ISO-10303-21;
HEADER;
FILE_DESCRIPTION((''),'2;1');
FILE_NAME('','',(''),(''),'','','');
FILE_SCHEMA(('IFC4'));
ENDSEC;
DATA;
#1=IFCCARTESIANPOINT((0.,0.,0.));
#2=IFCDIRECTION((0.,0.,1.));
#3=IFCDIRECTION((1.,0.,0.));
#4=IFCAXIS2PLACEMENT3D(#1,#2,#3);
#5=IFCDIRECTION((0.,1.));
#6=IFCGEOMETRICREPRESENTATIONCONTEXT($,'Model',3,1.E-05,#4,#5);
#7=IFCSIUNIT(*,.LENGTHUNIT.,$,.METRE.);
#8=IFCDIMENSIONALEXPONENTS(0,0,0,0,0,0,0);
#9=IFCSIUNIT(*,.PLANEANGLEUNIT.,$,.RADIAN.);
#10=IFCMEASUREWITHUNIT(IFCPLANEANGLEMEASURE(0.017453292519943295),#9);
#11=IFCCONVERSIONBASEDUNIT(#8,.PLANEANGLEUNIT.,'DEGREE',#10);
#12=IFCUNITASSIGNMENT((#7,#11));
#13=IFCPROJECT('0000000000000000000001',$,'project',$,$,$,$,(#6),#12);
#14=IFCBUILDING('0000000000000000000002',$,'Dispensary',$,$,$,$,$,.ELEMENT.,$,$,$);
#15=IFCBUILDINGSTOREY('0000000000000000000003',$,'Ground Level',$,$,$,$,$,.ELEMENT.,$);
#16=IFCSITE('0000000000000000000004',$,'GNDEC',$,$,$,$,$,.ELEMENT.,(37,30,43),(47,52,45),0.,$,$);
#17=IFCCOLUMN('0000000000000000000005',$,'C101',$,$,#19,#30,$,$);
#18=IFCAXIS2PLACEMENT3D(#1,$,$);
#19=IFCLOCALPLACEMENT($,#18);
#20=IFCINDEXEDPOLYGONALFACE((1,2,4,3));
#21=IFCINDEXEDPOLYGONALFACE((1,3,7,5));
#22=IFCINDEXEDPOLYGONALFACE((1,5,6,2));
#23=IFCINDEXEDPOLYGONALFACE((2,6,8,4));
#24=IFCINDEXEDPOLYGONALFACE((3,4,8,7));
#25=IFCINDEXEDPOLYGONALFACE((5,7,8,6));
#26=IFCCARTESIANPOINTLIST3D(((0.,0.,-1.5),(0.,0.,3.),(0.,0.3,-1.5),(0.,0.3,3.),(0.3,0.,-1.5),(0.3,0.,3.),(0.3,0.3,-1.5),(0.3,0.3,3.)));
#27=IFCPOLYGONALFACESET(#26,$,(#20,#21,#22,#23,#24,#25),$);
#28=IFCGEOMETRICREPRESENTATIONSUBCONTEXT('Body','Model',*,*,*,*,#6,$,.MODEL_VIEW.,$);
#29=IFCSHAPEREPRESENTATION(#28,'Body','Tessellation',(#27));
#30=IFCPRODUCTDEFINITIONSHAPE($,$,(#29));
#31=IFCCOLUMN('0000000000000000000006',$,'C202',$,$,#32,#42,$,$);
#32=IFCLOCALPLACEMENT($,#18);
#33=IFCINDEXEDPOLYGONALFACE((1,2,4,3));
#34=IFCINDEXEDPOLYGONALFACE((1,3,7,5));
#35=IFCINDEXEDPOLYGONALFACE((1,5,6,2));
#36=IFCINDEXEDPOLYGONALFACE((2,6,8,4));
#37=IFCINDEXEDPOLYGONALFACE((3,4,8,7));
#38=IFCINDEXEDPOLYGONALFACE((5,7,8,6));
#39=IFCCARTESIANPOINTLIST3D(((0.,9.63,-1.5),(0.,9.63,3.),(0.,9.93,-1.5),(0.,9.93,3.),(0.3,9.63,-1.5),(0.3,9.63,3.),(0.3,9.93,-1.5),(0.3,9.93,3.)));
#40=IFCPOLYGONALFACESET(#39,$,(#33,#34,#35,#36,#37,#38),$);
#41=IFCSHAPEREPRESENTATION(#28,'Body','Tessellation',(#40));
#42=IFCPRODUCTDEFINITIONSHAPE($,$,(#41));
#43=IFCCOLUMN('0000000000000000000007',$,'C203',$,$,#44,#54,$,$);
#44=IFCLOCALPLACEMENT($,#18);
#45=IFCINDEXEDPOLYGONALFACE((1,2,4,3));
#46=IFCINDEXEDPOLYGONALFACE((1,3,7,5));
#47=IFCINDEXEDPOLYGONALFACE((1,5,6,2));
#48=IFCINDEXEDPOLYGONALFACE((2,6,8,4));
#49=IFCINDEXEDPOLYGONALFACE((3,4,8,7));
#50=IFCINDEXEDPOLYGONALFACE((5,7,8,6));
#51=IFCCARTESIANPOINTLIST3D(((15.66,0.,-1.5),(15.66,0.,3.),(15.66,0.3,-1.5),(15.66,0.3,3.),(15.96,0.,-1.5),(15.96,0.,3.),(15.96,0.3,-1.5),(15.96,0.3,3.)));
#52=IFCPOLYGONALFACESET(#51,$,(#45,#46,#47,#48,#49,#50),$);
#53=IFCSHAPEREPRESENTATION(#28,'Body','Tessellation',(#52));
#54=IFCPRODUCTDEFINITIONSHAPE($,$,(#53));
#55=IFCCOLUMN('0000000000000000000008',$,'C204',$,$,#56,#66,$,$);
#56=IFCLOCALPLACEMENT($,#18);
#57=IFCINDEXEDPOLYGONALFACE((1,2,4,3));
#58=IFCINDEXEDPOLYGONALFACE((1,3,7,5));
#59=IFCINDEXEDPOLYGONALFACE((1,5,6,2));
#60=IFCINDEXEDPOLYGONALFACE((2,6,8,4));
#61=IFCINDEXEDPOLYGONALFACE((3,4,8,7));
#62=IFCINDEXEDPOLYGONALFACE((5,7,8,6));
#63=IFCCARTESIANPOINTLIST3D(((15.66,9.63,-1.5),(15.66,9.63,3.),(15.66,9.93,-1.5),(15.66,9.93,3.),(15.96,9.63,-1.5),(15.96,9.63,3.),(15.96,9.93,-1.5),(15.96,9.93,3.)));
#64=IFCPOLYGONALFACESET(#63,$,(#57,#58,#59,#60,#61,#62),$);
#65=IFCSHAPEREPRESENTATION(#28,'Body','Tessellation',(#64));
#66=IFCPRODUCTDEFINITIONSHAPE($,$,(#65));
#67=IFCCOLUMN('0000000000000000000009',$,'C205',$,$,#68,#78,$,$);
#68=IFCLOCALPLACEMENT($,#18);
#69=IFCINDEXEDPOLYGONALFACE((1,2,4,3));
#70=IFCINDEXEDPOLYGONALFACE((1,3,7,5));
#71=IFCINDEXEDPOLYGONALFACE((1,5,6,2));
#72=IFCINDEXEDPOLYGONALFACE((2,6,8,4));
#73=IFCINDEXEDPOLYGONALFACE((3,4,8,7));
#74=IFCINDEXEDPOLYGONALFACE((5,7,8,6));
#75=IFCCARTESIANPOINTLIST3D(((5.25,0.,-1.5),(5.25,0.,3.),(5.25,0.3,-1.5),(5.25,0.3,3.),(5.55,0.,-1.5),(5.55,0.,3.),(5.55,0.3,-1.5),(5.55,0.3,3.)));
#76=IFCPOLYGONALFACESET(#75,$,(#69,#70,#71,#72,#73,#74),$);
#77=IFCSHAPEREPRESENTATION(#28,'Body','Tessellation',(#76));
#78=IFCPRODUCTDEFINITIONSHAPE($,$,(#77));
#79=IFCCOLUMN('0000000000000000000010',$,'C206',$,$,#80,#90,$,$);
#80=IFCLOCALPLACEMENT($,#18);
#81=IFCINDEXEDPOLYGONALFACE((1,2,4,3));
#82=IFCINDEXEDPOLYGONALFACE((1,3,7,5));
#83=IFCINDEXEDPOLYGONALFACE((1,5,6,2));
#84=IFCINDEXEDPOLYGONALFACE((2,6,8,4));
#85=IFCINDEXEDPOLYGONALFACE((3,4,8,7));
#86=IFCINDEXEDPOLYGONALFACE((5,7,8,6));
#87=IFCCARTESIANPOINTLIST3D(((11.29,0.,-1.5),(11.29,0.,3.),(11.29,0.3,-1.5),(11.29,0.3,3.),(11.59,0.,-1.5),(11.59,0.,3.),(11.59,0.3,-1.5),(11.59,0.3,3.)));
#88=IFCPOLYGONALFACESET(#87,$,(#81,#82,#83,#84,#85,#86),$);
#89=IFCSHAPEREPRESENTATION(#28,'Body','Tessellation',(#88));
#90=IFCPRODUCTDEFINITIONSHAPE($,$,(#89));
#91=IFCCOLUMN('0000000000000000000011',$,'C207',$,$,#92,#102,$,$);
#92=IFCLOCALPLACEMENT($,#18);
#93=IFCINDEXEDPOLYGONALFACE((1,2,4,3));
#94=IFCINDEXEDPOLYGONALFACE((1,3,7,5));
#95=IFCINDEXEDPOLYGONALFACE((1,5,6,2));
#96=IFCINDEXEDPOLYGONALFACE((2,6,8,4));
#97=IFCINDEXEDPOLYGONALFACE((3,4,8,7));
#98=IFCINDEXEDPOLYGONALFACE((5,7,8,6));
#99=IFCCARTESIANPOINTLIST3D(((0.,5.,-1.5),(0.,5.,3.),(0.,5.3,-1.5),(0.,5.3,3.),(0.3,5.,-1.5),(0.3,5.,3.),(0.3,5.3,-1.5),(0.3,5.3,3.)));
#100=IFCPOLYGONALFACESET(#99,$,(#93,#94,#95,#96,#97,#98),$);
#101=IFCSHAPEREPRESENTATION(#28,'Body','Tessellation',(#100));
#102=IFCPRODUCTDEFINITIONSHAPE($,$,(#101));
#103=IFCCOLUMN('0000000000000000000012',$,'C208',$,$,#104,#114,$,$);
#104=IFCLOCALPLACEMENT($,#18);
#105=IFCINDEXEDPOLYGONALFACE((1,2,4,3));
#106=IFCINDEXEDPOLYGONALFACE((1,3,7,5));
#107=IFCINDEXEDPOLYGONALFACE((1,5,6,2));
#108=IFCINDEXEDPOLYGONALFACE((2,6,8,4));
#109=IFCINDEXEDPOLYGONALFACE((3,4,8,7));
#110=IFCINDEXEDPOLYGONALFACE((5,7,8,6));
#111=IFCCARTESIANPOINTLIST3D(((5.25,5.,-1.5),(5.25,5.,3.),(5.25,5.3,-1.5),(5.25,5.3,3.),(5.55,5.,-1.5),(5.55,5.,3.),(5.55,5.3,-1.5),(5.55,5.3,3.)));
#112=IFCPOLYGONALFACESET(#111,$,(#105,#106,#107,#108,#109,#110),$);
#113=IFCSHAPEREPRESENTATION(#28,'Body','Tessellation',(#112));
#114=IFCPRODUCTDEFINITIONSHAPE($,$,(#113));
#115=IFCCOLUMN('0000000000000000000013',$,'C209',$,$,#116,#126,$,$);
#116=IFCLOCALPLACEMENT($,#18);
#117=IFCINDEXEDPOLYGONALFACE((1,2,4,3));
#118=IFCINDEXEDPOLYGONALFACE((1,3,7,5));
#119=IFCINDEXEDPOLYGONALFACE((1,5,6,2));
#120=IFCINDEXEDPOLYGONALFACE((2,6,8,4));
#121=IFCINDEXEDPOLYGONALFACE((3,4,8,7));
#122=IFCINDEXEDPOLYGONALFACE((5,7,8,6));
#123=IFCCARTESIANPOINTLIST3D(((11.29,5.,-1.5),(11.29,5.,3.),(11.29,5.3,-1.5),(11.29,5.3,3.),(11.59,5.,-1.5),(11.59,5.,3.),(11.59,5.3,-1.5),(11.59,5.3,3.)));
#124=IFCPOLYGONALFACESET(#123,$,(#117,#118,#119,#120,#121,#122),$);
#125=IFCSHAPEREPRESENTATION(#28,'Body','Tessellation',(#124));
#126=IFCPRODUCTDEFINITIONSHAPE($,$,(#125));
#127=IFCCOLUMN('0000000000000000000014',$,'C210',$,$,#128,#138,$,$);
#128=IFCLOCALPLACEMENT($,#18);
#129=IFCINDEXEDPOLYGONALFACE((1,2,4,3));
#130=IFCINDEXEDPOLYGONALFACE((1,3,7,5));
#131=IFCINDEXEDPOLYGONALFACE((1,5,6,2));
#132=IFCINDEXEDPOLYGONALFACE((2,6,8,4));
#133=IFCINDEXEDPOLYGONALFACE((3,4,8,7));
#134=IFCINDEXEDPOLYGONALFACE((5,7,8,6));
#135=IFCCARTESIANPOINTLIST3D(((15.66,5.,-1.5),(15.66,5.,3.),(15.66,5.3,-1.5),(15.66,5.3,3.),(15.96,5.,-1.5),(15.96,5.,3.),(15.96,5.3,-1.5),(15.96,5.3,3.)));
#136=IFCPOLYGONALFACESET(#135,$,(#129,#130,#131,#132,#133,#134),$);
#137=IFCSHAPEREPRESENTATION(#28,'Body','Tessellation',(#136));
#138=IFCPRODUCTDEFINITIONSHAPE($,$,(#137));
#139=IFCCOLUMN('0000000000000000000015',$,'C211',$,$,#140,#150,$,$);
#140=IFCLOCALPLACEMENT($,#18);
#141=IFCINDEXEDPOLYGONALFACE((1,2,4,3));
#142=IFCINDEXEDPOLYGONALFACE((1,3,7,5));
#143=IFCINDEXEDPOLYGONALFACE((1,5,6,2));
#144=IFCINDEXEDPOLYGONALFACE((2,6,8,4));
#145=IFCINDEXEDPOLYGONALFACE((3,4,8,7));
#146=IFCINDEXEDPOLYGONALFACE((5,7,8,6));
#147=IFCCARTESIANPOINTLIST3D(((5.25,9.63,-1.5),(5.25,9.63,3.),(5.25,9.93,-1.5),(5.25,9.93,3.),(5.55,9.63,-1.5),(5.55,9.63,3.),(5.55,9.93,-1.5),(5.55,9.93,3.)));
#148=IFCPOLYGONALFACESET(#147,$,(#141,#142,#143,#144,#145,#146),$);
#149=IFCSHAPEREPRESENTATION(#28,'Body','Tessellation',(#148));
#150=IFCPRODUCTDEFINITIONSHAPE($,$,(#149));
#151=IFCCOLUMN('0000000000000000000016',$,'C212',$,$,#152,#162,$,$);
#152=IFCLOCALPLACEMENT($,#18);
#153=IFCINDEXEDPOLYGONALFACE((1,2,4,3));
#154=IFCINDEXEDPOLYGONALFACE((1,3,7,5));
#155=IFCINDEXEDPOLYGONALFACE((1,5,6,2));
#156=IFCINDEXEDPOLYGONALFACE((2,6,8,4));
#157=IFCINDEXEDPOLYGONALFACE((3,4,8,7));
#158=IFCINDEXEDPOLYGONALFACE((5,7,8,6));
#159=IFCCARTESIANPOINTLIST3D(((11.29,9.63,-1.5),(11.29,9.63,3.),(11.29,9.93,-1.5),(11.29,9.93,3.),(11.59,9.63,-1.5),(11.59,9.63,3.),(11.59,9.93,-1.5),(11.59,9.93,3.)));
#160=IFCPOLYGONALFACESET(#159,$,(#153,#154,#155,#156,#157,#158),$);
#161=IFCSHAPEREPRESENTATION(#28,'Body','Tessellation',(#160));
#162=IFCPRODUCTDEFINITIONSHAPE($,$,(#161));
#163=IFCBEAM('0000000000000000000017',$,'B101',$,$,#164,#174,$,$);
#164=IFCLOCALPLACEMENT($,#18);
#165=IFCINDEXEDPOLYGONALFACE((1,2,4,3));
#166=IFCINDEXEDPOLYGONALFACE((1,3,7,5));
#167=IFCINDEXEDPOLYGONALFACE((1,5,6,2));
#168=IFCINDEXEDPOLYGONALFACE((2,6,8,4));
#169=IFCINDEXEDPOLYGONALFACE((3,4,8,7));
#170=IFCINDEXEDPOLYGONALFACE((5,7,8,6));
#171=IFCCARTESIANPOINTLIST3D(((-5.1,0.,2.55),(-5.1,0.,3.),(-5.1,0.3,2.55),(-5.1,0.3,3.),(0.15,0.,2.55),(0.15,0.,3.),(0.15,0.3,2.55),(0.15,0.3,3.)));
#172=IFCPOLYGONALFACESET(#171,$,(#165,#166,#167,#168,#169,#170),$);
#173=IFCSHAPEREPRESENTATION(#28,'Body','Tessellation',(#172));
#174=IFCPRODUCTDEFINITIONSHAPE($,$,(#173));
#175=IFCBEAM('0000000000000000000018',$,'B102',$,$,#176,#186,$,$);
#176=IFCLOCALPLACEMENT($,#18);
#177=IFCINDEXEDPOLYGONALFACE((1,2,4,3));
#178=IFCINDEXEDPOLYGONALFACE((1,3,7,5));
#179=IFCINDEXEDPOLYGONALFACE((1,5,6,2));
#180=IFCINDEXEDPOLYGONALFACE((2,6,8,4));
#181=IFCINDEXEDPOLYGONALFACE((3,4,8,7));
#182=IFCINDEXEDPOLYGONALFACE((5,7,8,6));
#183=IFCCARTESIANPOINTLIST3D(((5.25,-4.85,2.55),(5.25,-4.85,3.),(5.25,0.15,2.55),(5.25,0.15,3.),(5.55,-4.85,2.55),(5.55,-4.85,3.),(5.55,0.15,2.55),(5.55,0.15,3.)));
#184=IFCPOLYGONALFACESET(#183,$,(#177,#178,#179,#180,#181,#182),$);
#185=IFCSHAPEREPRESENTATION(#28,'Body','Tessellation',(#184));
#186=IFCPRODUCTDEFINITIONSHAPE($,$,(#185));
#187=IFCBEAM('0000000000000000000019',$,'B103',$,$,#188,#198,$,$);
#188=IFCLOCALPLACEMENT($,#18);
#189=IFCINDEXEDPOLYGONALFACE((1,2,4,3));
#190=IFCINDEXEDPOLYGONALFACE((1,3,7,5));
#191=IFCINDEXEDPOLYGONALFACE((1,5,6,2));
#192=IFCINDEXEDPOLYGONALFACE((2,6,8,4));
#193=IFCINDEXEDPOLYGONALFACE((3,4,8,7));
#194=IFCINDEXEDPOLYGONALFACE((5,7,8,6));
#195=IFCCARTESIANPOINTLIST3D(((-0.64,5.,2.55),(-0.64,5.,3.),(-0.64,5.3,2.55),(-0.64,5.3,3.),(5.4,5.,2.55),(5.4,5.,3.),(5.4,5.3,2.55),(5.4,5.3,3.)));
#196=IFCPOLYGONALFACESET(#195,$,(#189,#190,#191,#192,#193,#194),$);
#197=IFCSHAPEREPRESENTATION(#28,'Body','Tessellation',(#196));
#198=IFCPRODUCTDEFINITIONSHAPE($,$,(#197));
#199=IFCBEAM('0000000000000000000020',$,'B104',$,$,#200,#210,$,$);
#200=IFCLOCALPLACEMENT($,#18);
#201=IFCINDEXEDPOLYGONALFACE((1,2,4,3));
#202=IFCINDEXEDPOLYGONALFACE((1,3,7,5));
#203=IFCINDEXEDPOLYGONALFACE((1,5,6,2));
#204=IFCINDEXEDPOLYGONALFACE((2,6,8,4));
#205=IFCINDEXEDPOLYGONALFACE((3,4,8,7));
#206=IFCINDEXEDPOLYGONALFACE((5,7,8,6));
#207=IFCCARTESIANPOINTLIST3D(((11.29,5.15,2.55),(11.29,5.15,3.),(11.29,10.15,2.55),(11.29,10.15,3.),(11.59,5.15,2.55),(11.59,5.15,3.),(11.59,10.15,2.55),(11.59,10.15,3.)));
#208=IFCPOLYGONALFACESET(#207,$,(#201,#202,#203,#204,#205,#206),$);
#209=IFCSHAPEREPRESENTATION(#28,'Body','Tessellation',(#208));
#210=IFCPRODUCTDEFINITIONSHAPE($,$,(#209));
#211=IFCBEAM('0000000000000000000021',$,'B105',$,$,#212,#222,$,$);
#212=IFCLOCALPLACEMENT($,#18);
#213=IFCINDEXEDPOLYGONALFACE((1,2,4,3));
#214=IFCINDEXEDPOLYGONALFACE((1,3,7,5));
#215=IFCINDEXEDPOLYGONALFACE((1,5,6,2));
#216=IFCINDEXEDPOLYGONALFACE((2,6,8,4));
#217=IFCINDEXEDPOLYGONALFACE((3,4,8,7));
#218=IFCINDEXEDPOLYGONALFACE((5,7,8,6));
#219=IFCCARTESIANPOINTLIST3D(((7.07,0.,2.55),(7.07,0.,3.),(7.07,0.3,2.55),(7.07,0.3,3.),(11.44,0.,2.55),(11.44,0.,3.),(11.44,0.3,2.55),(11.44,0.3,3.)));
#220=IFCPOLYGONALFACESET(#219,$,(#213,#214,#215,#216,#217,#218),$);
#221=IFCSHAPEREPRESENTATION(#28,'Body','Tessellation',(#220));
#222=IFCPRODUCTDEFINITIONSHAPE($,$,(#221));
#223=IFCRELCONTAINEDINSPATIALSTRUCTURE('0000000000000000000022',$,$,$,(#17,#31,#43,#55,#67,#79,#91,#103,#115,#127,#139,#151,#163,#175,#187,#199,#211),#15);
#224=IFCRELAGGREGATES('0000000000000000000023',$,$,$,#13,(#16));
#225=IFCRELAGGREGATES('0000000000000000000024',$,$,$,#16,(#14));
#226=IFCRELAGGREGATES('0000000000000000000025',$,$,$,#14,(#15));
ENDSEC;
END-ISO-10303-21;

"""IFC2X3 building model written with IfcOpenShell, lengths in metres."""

from ifc_helpers import new_model, entity, si_unit, converted_unit, direction, frame, frame_2d, origin_with_axes, place, context, subcontext, project, spatial, rectangle, extrude, element, save


model = new_model("IFC2X3")

# Units and contexts
model_context = context("Model", 3, precision=1e-05, world=origin_with_axes(), true_north=direction((0.0, 1.0)))
body_context = subcontext(model_context, "Body", "Model", "MODEL_VIEW")
ifc_project = project(units=[si_unit("LENGTHUNIT", "METRE"), converted_unit("PLANEANGLEUNIT", "DEGREE", entity("IfcPlaneAngleMeasure", 0.017453292519943295), si_unit("PLANEANGLEUNIT", "RADIAN"), dimensions=[0, 0, 0, 0, 0, 0, 0])], contexts=[model_context])

# Site, building, storey
site = spatial("IfcSite", under=ifc_project, Name="GNDEC", CompositionType="ELEMENT", RefLatitude=(37, 30, 43), RefLongitude=(47, 52, 45), RefElevation=0.0)
building = spatial("IfcBuilding", under=site, Name="Dispensary", CompositionType="ELEMENT")
storey = spatial("IfcBuildingStorey", under=building, Name="Ground Level", CompositionType="ELEMENT")

# Columns
placement = place(None, origin_with_axes())
element("IfcColumn", 1, at=placement, inside=storey, Name="C101", context=body_context, shape_type="SweptSolid", body=[
    extrude(rectangle(XDim=0.3, YDim=0.3, at=frame_2d((0.0, 0.0), x_axis=(1.0, 0.0))), frame((0.15, 0.15, -1.5), z_axis=(0.0, 0.0, 1.0), x_axis=(1.0, 0.0, 0.0)), (0.0, 0.0, 1.0), 4.5),
])
element("IfcColumn", 2, at=placement, inside=storey, Name="C202", context=body_context, shape_type="SweptSolid", body=[
    extrude(rectangle(XDim=0.3, YDim=0.3, at=frame_2d((0.0, 0.0), x_axis=(1.0, 0.0))), frame((0.15, 9.78, -1.5), z_axis=(0.0, 0.0, 1.0), x_axis=(1.0, 0.0, 0.0)), (0.0, 0.0, 1.0), 4.5),
])
element("IfcColumn", 3, at=placement, inside=storey, Name="C203", context=body_context, shape_type="SweptSolid", body=[
    extrude(rectangle(XDim=0.3, YDim=0.3, at=frame_2d((0.0, 0.0), x_axis=(1.0, 0.0))), frame((15.81, 0.15, -1.5), z_axis=(0.0, 0.0, 1.0), x_axis=(1.0, 0.0, 0.0)), (0.0, 0.0, 1.0), 4.5),
])
element("IfcColumn", 4, at=placement, inside=storey, Name="C204", context=body_context, shape_type="SweptSolid", body=[
    extrude(rectangle(XDim=0.3, YDim=0.3, at=frame_2d((0.0, 0.0), x_axis=(1.0, 0.0))), frame((15.81, 9.78, -1.5), z_axis=(0.0, 0.0, 1.0), x_axis=(1.0, 0.0, 0.0)), (0.0, 0.0, 1.0), 4.5),
])
element("IfcColumn", 5, at=placement, inside=storey, Name="C205", context=body_context, shape_type="SweptSolid", body=[
    extrude(rectangle(XDim=0.3, YDim=0.3, at=frame_2d((0.0, 0.0), x_axis=(1.0, 0.0))), frame((5.4, 0.15, -1.5), z_axis=(0.0, 0.0, 1.0), x_axis=(1.0, 0.0, 0.0)), (0.0, 0.0, 1.0), 4.5),
])
element("IfcColumn", 6, at=placement, inside=storey, Name="C206", context=body_context, shape_type="SweptSolid", body=[
    extrude(rectangle(XDim=0.3, YDim=0.3, at=frame_2d((0.0, 0.0), x_axis=(1.0, 0.0))), frame((11.44, 0.15, -1.5), z_axis=(0.0, 0.0, 1.0), x_axis=(1.0, 0.0, 0.0)), (0.0, 0.0, 1.0), 4.5),
])
element("IfcColumn", 7, at=placement, inside=storey, Name="C207", context=body_context, shape_type="SweptSolid", body=[
    extrude(rectangle(XDim=0.3, YDim=0.3, at=frame_2d((0.0, 0.0), x_axis=(1.0, 0.0))), frame((0.15, 5.15, -1.5), z_axis=(0.0, 0.0, 1.0), x_axis=(1.0, 0.0, 0.0)), (0.0, 0.0, 1.0), 4.5),
])
element("IfcColumn", 8, at=placement, inside=storey, Name="C208", context=body_context, shape_type="SweptSolid", body=[
    extrude(rectangle(XDim=0.3, YDim=0.3, at=frame_2d((0.0, 0.0), x_axis=(1.0, 0.0))), frame((5.4, 5.15, -1.5), z_axis=(0.0, 0.0, 1.0), x_axis=(1.0, 0.0, 0.0)), (0.0, 0.0, 1.0), 4.5),
])
element("IfcColumn", 9, at=placement, inside=storey, Name="C209", context=body_context, shape_type="SweptSolid", body=[
    extrude(rectangle(XDim=0.3, YDim=0.3, at=frame_2d((0.0, 0.0), x_axis=(1.0, 0.0))), frame((11.44, 5.15, -1.5), z_axis=(0.0, 0.0, 1.0), x_axis=(1.0, 0.0, 0.0)), (0.0, 0.0, 1.0), 4.5),
])
element("IfcColumn", 10, at=placement, inside=storey, Name="C210", context=body_context, shape_type="SweptSolid", body=[
    extrude(rectangle(XDim=0.3, YDim=0.3, at=frame_2d((0.0, 0.0), x_axis=(1.0, 0.0))), frame((15.81, 5.15, -1.5), z_axis=(0.0, 0.0, 1.0), x_axis=(1.0, 0.0, 0.0)), (0.0, 0.0, 1.0), 4.5),
])
element("IfcColumn", 11, at=placement, inside=storey, Name="C211", context=body_context, shape_type="SweptSolid", body=[
    extrude(rectangle(XDim=0.3, YDim=0.3, at=frame_2d((0.0, 0.0), x_axis=(1.0, 0.0))), frame((5.4, 9.78, -1.5), z_axis=(0.0, 0.0, 1.0), x_axis=(1.0, 0.0, 0.0)), (0.0, 0.0, 1.0), 4.5),
])
element("IfcColumn", 12, at=placement, inside=storey, Name="C212", context=body_context, shape_type="SweptSolid", body=[
    extrude(rectangle(XDim=0.3, YDim=0.3, at=frame_2d((0.0, 0.0), x_axis=(1.0, 0.0))), frame((11.44, 9.78, -1.5), z_axis=(0.0, 0.0, 1.0), x_axis=(1.0, 0.0, 0.0)), (0.0, 0.0, 1.0), 4.5),
])

# Beams
element("IfcBeam", 13, at=placement, inside=storey, Name="B101", context=body_context, shape_type="SweptSolid", body=[
    extrude(rectangle(XDim=0.3, YDim=0.45, at=frame_2d((0.0, 0.0), x_axis=(0.0, 1.0))), frame((0.15, 0.15, 2.775), z_axis=(-1.0, 0.0, 0.0), x_axis=(0.0, 0.0, 1.0)), (0.0, 0.0, 1.0), 5.25),
])
element("IfcBeam", 14, at=placement, inside=storey, Name="B102", context=body_context, shape_type="SweptSolid", body=[
    extrude(rectangle(XDim=0.3, YDim=0.45, at=frame_2d((0.0, 0.0), x_axis=(0.0, 1.0))), frame((5.4, 0.15, 2.775), z_axis=(0.0, -1.0, 0.0), x_axis=(0.0, 0.0, 1.0)), (0.0, 0.0, 1.0), 5.0),
])
element("IfcBeam", 15, at=placement, inside=storey, Name="B103", context=body_context, shape_type="SweptSolid", body=[
    extrude(rectangle(XDim=0.3, YDim=0.45, at=frame_2d((0.0, 0.0), x_axis=(0.0, 1.0))), frame((5.4, 5.15, 2.775), z_axis=(-1.0, 0.0, 0.0), x_axis=(0.0, 0.0, 1.0)), (0.0, 0.0, 1.0), 6.04),
])
element("IfcBeam", 16, at=placement, inside=storey, Name="B104", context=body_context, shape_type="SweptSolid", body=[
    extrude(rectangle(XDim=0.3, YDim=0.45, at=frame_2d((0.0, 0.0), x_axis=(0.0, 1.0))), frame((11.44, 5.15, 2.775), z_axis=(0.0, 1.0, 0.0), x_axis=(0.0, 0.0, 1.0)), (0.0, 0.0, 1.0), 5.0),
])
element("IfcBeam", 17, at=placement, inside=storey, Name="B105", context=body_context, shape_type="SweptSolid", body=[
    extrude(rectangle(XDim=0.3, YDim=0.45, at=frame_2d((0.0, 0.0), x_axis=(0.0, 1.0))), frame((11.44, 0.15, 2.775), z_axis=(-1.0, 0.0, 0.0), x_axis=(0.0, 0.0, 1.0)), (0.0, 0.0, 1.0), 4.37),
])

save(model, "model.ifc")
